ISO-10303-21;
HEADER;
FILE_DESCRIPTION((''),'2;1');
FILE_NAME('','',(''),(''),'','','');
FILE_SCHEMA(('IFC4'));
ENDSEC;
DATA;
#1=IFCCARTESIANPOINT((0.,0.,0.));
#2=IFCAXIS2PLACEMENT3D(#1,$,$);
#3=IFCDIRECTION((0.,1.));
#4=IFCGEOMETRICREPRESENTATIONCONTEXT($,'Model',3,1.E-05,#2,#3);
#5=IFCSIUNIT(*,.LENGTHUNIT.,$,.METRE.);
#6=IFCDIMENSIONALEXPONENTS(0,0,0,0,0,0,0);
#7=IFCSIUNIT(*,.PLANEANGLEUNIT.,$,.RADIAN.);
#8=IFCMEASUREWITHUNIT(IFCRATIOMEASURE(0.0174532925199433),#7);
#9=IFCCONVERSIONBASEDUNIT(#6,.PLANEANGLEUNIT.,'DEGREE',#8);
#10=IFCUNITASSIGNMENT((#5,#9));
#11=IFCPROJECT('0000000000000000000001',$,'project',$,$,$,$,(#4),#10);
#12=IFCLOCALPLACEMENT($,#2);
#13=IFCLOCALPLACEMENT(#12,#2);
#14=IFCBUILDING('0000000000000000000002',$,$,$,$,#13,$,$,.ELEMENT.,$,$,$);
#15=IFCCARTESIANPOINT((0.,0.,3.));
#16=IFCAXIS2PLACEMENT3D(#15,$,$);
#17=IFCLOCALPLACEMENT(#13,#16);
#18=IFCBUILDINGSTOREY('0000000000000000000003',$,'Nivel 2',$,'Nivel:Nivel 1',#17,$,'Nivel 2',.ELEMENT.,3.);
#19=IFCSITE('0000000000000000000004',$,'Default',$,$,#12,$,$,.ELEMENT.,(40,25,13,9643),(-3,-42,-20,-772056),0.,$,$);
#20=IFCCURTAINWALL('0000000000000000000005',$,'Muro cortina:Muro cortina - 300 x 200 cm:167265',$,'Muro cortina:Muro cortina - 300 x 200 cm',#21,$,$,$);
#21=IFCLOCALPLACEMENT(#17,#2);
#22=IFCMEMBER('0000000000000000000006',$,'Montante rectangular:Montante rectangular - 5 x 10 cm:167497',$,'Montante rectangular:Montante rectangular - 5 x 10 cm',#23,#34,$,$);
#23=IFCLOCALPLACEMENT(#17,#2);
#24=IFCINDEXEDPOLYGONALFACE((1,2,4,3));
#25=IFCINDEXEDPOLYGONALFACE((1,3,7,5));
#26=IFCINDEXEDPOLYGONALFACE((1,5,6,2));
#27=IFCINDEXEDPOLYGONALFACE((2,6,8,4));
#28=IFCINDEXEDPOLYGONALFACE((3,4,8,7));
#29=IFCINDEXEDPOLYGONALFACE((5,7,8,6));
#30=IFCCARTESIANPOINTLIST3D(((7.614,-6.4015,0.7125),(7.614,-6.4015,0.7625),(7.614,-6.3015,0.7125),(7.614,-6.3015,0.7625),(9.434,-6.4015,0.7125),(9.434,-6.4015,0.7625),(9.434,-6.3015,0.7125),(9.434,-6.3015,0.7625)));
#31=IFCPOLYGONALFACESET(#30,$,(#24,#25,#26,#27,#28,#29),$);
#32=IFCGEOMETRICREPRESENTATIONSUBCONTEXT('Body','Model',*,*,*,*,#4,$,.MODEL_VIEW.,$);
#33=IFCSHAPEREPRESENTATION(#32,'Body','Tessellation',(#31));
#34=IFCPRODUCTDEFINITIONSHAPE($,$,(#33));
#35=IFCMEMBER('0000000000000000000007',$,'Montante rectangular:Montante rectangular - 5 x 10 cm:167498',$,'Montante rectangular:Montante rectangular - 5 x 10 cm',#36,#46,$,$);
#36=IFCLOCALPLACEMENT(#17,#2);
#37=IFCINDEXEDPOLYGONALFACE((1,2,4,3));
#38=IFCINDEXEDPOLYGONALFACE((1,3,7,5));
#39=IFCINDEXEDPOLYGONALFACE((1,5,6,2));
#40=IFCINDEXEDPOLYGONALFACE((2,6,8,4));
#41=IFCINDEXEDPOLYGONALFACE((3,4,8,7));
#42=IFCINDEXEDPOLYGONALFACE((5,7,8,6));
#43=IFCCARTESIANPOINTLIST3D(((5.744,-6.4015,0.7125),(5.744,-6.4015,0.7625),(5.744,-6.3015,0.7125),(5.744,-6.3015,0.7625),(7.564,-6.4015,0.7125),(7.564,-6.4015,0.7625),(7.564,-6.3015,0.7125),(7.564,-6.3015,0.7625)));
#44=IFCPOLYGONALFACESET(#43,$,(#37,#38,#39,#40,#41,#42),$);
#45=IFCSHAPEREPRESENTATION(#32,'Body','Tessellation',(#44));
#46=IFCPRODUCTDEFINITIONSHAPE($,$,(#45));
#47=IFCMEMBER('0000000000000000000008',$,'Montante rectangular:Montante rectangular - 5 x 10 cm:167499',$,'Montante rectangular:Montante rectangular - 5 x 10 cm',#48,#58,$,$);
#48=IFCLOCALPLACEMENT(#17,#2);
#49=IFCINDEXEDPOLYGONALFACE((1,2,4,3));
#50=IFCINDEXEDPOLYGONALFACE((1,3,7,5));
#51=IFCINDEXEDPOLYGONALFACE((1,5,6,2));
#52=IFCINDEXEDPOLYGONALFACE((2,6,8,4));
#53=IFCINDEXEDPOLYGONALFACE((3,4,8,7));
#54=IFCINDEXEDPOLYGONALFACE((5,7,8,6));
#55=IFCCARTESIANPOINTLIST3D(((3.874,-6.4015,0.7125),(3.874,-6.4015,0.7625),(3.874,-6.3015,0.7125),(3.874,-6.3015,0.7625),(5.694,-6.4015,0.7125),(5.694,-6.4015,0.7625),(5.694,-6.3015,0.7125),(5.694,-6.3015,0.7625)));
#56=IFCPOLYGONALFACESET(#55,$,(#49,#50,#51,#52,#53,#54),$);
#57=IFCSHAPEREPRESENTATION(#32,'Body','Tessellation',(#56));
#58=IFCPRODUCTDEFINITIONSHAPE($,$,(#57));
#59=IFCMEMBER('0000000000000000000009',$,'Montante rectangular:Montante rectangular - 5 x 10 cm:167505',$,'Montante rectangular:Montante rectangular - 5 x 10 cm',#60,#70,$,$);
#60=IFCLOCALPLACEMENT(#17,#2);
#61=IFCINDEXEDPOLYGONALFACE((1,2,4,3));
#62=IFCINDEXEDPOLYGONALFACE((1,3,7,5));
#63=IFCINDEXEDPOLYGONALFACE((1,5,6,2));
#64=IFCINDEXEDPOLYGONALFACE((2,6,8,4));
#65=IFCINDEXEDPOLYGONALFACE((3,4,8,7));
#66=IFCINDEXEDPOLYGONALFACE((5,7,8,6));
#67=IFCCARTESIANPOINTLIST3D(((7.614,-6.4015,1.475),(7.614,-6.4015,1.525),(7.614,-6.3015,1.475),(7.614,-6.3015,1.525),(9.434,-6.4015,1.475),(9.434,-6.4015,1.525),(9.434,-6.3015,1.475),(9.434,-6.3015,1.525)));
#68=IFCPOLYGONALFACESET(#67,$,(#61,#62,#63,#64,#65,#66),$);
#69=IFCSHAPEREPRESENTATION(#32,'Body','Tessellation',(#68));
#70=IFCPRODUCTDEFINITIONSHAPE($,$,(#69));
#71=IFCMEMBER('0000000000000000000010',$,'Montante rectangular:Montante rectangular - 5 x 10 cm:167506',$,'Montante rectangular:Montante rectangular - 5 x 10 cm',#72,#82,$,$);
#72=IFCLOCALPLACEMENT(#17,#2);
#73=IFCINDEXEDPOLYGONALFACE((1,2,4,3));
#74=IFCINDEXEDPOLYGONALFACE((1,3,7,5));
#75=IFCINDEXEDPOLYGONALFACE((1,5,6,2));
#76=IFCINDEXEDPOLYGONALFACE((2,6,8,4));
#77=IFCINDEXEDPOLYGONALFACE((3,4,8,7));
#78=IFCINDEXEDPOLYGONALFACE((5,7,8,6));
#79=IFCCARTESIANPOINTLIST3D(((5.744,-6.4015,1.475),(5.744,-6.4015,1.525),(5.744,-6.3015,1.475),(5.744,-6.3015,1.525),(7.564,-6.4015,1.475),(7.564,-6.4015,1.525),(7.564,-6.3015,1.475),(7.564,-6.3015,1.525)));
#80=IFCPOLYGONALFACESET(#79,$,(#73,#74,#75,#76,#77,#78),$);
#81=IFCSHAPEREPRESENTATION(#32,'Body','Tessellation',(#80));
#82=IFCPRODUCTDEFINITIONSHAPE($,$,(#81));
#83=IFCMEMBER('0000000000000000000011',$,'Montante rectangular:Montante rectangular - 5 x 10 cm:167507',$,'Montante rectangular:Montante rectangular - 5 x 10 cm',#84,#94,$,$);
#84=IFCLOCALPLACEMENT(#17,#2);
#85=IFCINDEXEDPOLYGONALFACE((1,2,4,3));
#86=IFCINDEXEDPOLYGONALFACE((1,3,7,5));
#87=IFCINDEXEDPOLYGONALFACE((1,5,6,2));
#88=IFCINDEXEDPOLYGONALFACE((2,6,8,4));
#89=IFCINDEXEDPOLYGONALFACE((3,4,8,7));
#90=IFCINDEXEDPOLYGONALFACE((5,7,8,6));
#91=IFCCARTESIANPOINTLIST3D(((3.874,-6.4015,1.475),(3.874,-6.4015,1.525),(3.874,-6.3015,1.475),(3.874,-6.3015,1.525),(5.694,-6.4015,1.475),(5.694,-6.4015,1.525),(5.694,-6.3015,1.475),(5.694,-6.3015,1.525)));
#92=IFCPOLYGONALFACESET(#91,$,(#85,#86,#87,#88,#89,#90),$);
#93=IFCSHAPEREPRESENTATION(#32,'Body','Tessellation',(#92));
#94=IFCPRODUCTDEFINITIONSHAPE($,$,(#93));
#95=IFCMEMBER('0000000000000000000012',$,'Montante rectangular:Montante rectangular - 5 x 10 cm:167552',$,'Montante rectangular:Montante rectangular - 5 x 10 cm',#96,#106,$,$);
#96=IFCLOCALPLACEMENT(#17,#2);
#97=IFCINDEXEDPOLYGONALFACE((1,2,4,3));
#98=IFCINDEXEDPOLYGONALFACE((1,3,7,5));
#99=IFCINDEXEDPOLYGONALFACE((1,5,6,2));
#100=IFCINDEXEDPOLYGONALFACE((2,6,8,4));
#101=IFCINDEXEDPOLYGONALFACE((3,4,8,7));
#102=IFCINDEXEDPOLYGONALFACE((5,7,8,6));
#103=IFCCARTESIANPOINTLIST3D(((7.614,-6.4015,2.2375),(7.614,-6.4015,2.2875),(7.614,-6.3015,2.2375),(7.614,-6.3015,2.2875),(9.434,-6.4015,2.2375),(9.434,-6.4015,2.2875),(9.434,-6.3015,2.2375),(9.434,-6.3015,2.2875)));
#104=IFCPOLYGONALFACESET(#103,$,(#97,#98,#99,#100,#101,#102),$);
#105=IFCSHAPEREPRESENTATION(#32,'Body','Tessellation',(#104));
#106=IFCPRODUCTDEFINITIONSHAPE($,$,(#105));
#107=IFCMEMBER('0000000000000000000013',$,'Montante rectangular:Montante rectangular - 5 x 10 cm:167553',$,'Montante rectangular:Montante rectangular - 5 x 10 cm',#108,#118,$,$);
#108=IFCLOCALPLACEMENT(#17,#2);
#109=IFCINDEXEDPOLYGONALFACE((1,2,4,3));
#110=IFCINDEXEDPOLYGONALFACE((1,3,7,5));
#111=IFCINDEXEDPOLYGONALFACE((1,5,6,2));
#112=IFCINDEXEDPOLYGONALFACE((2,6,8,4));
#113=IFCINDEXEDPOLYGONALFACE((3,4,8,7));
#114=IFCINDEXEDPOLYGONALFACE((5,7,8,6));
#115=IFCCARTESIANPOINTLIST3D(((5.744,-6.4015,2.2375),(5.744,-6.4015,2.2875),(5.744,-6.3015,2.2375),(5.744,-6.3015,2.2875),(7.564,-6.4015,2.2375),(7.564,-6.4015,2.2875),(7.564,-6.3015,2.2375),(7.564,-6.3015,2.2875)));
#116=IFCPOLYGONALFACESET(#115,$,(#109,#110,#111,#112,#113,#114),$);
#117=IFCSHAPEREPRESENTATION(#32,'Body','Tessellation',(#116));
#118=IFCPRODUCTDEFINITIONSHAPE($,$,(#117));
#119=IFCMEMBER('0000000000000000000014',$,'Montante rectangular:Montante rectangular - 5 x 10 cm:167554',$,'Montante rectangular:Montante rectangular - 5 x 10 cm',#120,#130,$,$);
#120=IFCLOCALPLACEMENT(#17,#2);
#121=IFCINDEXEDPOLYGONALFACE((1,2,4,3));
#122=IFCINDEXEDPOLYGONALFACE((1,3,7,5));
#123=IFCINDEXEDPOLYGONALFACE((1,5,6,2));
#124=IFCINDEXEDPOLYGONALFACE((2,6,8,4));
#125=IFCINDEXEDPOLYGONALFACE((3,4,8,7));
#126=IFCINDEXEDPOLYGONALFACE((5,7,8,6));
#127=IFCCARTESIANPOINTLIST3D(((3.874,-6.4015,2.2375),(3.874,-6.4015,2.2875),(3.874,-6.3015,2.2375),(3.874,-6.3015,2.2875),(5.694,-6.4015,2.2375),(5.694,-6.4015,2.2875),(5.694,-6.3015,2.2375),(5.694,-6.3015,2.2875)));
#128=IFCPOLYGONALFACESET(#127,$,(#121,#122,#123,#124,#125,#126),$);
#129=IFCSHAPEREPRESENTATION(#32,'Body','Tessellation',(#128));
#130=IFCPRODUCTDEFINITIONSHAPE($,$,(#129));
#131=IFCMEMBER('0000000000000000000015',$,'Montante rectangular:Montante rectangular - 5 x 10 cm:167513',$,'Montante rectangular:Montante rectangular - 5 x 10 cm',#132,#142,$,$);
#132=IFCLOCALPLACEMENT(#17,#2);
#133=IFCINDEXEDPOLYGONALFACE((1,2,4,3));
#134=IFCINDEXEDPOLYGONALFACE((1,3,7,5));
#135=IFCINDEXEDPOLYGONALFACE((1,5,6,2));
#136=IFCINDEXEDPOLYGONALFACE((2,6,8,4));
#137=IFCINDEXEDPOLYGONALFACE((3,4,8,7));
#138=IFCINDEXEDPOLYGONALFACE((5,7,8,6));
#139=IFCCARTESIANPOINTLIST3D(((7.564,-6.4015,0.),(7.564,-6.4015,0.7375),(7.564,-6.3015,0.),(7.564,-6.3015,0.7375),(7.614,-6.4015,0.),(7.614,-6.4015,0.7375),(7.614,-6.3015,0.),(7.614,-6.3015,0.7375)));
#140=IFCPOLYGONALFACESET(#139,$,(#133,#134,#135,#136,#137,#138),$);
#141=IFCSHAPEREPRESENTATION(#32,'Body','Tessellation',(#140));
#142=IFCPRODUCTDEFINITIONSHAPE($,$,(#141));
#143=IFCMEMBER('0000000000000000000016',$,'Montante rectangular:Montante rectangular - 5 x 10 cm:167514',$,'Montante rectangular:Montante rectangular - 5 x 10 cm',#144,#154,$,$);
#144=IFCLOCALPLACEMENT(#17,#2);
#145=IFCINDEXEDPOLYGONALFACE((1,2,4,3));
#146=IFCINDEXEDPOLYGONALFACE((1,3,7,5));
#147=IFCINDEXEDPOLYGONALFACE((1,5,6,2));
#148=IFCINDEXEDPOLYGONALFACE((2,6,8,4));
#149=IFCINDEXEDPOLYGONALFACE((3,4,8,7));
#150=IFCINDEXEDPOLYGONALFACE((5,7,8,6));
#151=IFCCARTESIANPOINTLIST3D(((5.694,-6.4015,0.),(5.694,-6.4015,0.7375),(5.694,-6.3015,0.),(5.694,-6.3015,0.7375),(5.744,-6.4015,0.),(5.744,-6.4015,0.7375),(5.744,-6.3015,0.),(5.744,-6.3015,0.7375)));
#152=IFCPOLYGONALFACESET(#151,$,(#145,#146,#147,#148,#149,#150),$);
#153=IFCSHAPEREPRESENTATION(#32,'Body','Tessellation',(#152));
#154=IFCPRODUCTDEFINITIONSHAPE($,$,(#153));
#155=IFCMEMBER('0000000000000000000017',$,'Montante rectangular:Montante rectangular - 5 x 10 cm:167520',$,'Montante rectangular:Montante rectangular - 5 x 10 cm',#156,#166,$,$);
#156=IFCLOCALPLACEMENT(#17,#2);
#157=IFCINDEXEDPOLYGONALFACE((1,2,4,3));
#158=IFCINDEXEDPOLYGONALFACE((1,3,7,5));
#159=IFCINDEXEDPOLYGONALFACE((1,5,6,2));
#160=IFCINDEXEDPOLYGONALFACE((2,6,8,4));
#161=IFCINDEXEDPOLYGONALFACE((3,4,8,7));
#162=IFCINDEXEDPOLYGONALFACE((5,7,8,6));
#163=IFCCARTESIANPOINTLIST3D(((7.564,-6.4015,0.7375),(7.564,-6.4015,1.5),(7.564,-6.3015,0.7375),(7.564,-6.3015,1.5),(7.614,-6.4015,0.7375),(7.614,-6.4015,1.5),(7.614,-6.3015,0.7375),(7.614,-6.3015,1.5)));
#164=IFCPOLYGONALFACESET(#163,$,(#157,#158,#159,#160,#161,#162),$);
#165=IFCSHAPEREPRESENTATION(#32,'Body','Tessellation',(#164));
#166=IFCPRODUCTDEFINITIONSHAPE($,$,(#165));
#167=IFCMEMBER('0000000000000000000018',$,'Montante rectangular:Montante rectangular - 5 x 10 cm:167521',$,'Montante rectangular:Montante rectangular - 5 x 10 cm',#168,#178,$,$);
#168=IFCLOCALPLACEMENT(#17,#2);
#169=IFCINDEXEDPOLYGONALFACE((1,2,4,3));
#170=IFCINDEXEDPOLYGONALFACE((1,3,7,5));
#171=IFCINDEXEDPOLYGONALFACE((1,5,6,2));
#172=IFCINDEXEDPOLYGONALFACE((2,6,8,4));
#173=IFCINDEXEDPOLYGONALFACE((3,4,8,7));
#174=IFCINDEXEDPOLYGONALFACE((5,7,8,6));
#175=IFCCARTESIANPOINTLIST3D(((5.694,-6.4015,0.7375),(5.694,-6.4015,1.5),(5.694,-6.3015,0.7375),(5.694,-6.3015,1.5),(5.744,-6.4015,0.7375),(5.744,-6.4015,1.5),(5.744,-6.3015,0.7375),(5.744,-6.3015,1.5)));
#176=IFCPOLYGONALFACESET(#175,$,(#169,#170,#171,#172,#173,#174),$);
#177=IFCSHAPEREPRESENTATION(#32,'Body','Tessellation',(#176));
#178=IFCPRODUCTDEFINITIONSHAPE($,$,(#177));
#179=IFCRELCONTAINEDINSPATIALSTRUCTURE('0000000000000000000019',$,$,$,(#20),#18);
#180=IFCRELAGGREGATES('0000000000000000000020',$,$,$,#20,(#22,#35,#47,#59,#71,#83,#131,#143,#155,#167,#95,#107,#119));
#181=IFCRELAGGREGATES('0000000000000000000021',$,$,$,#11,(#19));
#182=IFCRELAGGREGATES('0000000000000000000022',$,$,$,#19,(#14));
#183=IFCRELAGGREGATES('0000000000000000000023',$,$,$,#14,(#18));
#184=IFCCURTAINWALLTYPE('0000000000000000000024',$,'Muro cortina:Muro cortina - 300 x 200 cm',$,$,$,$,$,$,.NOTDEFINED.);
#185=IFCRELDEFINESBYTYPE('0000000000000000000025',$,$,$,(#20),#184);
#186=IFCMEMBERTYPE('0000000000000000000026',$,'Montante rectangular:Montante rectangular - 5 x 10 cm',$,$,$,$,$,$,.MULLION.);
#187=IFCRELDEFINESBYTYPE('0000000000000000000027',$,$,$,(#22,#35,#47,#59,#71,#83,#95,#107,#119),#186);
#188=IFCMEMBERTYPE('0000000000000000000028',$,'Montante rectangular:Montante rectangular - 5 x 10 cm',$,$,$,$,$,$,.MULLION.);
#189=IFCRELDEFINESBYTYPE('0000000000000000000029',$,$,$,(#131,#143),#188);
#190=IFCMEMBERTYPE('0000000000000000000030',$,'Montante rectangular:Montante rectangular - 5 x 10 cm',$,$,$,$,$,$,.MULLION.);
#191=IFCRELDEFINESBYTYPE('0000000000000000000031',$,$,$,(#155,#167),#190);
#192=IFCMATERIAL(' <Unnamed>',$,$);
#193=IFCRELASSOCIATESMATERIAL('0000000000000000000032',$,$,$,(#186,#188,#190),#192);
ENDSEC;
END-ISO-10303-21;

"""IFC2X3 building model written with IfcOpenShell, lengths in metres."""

from ifc_helpers import new_model, entity, si_unit, converted_unit, direction, frame, origin, origin_2d_with_axis, place, context, subcontext, project, spatial, rectangle, extrude, source, transform, mapped, material, type_object, type_shapes, element, aggregate, save


model = new_model("IFC2X3")

# Units and contexts
model_context = context("Model", 3, precision=1e-05, world=origin(), true_north=direction((0.0, 1.0)))
body_context = subcontext(model_context, "Body", "Model", "MODEL_VIEW")
ifc_project = project(units=[si_unit("LENGTHUNIT", "METRE"), converted_unit("PLANEANGLEUNIT", "DEGREE", entity("IfcRatioMeasure", 0.0174532925199433), si_unit("PLANEANGLEUNIT", "RADIAN"), dimensions=[0, 0, 0, 0, 0, 0, 0])], contexts=[model_context])

# Site, building, storey
site_placement = place(None, origin())
site = spatial("IfcSite", under=ifc_project, at=site_placement, Name="Default", CompositionType="ELEMENT", RefLatitude=(40, 25, 13, 9643), RefLongitude=(-3, -42, -20, -772056), RefElevation=0.0)
building_placement = place(site_placement, origin())
building = spatial("IfcBuilding", under=site, at=building_placement, CompositionType="ELEMENT")
storey_placement = place(building_placement, frame((0.0, 0.0, 3.0)))
storey = spatial("IfcBuildingStorey", under=building, at=storey_placement, Name="Nivel 2", ObjectType="Nivel:Nivel 1", LongName="Nivel 2", CompositionType="ELEMENT", Elevation=3.0)

# Curtain wall, members
curtain_wall_type = type_object("IfcCurtainWallType", Name="Muro cortina:Muro cortina - 300 x 200 cm", PredefinedType="NOTDEFINED")
curtain_wall_placement = place(storey_placement, frame((0.0, 0.0, -3.0)))
curtain_wall = element("IfcCurtainWall", 1, at=curtain_wall_placement, inside=storey, type_object=curtain_wall_type, Name="Muro cortina:Muro cortina - 300 x 200 cm:167265", ObjectType="Muro cortina:Muro cortina - 300 x 200 cm")
ifc_material_1 = material(Name=" <Unnamed>")
member_type_1 = type_object("IfcMemberType", Name="Montante rectangular:Montante rectangular - 5 x 10 cm", PredefinedType="MULLION", material=ifc_material_1)
shared_shape_1 = source(origin(), body_context, "Body", "SweptSolid", [
    extrude(rectangle(XDim=0.1, YDim=0.05, at=origin_2d_with_axis()), frame((0.0, 0.0, -1.82), z_axis=(0.0, 0.0, 1.0), x_axis=(0.0, -1.0, 0.0)), (0.0, 0.0, 1.0), 1.82),
])
type_shapes(member_type_1, [shared_shape_1])
member_1_placement = place(storey_placement, frame((7.614, -6.3515, 0.7375), z_axis=(-1.0, 0.0, 0.0), x_axis=(0.0, 0.0, 1.0)))
member_1 = element("IfcMember", 2, at=member_1_placement, type_object=member_type_1, Name="Montante rectangular:Montante rectangular - 5 x 10 cm:167497", ObjectType="Montante rectangular:Montante rectangular - 5 x 10 cm", context=body_context, shape_type="MappedRepresentation", body=[
    mapped(shared_shape_1, transform((0.0, 0.0, 0.0), scale=1.0)),
])
member_2_placement = place(storey_placement, frame((5.744, -6.3515, 0.7375), z_axis=(-1.0, 0.0, 0.0), x_axis=(0.0, 0.0, 1.0)))
member_2 = element("IfcMember", 3, at=member_2_placement, type_object=member_type_1, Name="Montante rectangular:Montante rectangular - 5 x 10 cm:167498", ObjectType="Montante rectangular:Montante rectangular - 5 x 10 cm", context=body_context, shape_type="MappedRepresentation", body=[
    mapped(shared_shape_1, transform((0.0, 0.0, 0.0), scale=1.0)),
])
member_3_placement = place(storey_placement, frame((3.874, -6.3515, 0.7375), z_axis=(-1.0, 0.0, 0.0), x_axis=(0.0, 0.0, 1.0)))
member_3 = element("IfcMember", 4, at=member_3_placement, type_object=member_type_1, Name="Montante rectangular:Montante rectangular - 5 x 10 cm:167499", ObjectType="Montante rectangular:Montante rectangular - 5 x 10 cm", context=body_context, shape_type="MappedRepresentation", body=[
    mapped(shared_shape_1, transform((0.0, 0.0, 0.0), scale=1.0)),
])
member_4_placement = place(storey_placement, frame((7.614, -6.3515, 1.5), z_axis=(-1.0, 0.0, 0.0), x_axis=(0.0, 0.0, 1.0)))
member_4 = element("IfcMember", 5, at=member_4_placement, type_object=member_type_1, Name="Montante rectangular:Montante rectangular - 5 x 10 cm:167505", ObjectType="Montante rectangular:Montante rectangular - 5 x 10 cm", context=body_context, shape_type="MappedRepresentation", body=[
    mapped(shared_shape_1, transform((0.0, 0.0, 0.0), scale=1.0)),
])
member_5_placement = place(storey_placement, frame((5.744, -6.3515, 1.5), z_axis=(-1.0, 0.0, 0.0), x_axis=(0.0, 0.0, 1.0)))
member_5 = element("IfcMember", 6, at=member_5_placement, type_object=member_type_1, Name="Montante rectangular:Montante rectangular - 5 x 10 cm:167506", ObjectType="Montante rectangular:Montante rectangular - 5 x 10 cm", context=body_context, shape_type="MappedRepresentation", body=[
    mapped(shared_shape_1, transform((0.0, 0.0, 0.0), scale=1.0)),
])
member_6_placement = place(storey_placement, frame((3.874, -6.3515, 1.5), z_axis=(-1.0, 0.0, 0.0), x_axis=(0.0, 0.0, 1.0)))
member_6 = element("IfcMember", 7, at=member_6_placement, type_object=member_type_1, Name="Montante rectangular:Montante rectangular - 5 x 10 cm:167507", ObjectType="Montante rectangular:Montante rectangular - 5 x 10 cm", context=body_context, shape_type="MappedRepresentation", body=[
    mapped(shared_shape_1, transform((0.0, 0.0, 0.0), scale=1.0)),
])
member_7_placement = place(storey_placement, frame((7.614, -6.3515, 2.2625), z_axis=(-1.0, 0.0, 0.0), x_axis=(0.0, 0.0, 1.0)))
member_7 = element("IfcMember", 8, at=member_7_placement, type_object=member_type_1, Name="Montante rectangular:Montante rectangular - 5 x 10 cm:167552", ObjectType="Montante rectangular:Montante rectangular - 5 x 10 cm", context=body_context, shape_type="MappedRepresentation", body=[
    mapped(shared_shape_1, transform((0.0, 0.0, 0.0), scale=1.0)),
])
member_8_placement = place(storey_placement, frame((5.744, -6.3515, 2.2625), z_axis=(-1.0, 0.0, 0.0), x_axis=(0.0, 0.0, 1.0)))
member_8 = element("IfcMember", 9, at=member_8_placement, type_object=member_type_1, Name="Montante rectangular:Montante rectangular - 5 x 10 cm:167553", ObjectType="Montante rectangular:Montante rectangular - 5 x 10 cm", context=body_context, shape_type="MappedRepresentation", body=[
    mapped(shared_shape_1, transform((0.0, 0.0, 0.0), scale=1.0)),
])
member_9_placement = place(storey_placement, frame((3.874, -6.3515, 2.2625), z_axis=(-1.0, 0.0, 0.0), x_axis=(0.0, 0.0, 1.0)))
member_9 = element("IfcMember", 10, at=member_9_placement, type_object=member_type_1, Name="Montante rectangular:Montante rectangular - 5 x 10 cm:167554", ObjectType="Montante rectangular:Montante rectangular - 5 x 10 cm", context=body_context, shape_type="MappedRepresentation", body=[
    mapped(shared_shape_1, transform((0.0, 0.0, 0.0), scale=1.0)),
])
member_type_2 = type_object("IfcMemberType", Name="Montante rectangular:Montante rectangular - 5 x 10 cm", PredefinedType="MULLION", material=ifc_material_1)
shared_shape_2 = source(origin(), body_context, "Body", "SweptSolid", [
    extrude(rectangle(XDim=0.1, YDim=0.05, at=origin_2d_with_axis()), frame((0.0, 0.0, -0.7375), z_axis=(0.0, 0.0, 1.0), x_axis=(0.0, -1.0, 0.0)), (0.0, 0.0, 1.0), 0.7375),
])
type_shapes(member_type_2, [shared_shape_2])
member_10_placement = place(storey_placement, frame((7.589, -6.3515, 0.0), z_axis=(0.0, 0.0, -1.0), x_axis=(-1.0, 0.0, 0.0)))
member_10 = element("IfcMember", 11, at=member_10_placement, type_object=member_type_2, Name="Montante rectangular:Montante rectangular - 5 x 10 cm:167513", ObjectType="Montante rectangular:Montante rectangular - 5 x 10 cm", context=body_context, shape_type="MappedRepresentation", body=[
    mapped(shared_shape_2, transform((0.0, 0.0, 0.0), scale=1.0)),
])
member_11_placement = place(storey_placement, frame((5.719, -6.3515, 0.0), z_axis=(0.0, 0.0, -1.0), x_axis=(-1.0, 0.0, 0.0)))
member_11 = element("IfcMember", 12, at=member_11_placement, type_object=member_type_2, Name="Montante rectangular:Montante rectangular - 5 x 10 cm:167514", ObjectType="Montante rectangular:Montante rectangular - 5 x 10 cm", context=body_context, shape_type="MappedRepresentation", body=[
    mapped(shared_shape_2, transform((0.0, 0.0, 0.0), scale=1.0)),
])
member_type_3 = type_object("IfcMemberType", Name="Montante rectangular:Montante rectangular - 5 x 10 cm", PredefinedType="MULLION", material=ifc_material_1)
shared_shape_3 = source(origin(), body_context, "Body", "SweptSolid", [
    extrude(rectangle(XDim=0.1, YDim=0.05, at=origin_2d_with_axis()), frame((0.0, 0.0, -0.7625), z_axis=(0.0, 0.0, 1.0), x_axis=(0.0, -1.0, 0.0)), (0.0, 0.0, 1.0), 0.7625),
])
type_shapes(member_type_3, [shared_shape_3])
member_12_placement = place(storey_placement, frame((7.589, -6.3515, 0.7375), z_axis=(0.0, 0.0, -1.0), x_axis=(-1.0, 0.0, 0.0)))
member_12 = element("IfcMember", 13, at=member_12_placement, type_object=member_type_3, Name="Montante rectangular:Montante rectangular - 5 x 10 cm:167520", ObjectType="Montante rectangular:Montante rectangular - 5 x 10 cm", context=body_context, shape_type="MappedRepresentation", body=[
    mapped(shared_shape_3, transform((0.0, 0.0, 0.0), scale=1.0)),
])
member_13_placement = place(storey_placement, frame((5.719, -6.3515, 0.7375), z_axis=(0.0, 0.0, -1.0), x_axis=(-1.0, 0.0, 0.0)))
member_13 = element("IfcMember", 14, at=member_13_placement, type_object=member_type_3, Name="Montante rectangular:Montante rectangular - 5 x 10 cm:167521", ObjectType="Montante rectangular:Montante rectangular - 5 x 10 cm", context=body_context, shape_type="MappedRepresentation", body=[
    mapped(shared_shape_3, transform((0.0, 0.0, 0.0), scale=1.0)),
])
aggregate(curtain_wall, [member_1, member_2, member_3, member_4, member_5, member_6, member_10, member_11, member_12, member_13, member_7, member_8, member_9])

save(model, "model.ifc")
